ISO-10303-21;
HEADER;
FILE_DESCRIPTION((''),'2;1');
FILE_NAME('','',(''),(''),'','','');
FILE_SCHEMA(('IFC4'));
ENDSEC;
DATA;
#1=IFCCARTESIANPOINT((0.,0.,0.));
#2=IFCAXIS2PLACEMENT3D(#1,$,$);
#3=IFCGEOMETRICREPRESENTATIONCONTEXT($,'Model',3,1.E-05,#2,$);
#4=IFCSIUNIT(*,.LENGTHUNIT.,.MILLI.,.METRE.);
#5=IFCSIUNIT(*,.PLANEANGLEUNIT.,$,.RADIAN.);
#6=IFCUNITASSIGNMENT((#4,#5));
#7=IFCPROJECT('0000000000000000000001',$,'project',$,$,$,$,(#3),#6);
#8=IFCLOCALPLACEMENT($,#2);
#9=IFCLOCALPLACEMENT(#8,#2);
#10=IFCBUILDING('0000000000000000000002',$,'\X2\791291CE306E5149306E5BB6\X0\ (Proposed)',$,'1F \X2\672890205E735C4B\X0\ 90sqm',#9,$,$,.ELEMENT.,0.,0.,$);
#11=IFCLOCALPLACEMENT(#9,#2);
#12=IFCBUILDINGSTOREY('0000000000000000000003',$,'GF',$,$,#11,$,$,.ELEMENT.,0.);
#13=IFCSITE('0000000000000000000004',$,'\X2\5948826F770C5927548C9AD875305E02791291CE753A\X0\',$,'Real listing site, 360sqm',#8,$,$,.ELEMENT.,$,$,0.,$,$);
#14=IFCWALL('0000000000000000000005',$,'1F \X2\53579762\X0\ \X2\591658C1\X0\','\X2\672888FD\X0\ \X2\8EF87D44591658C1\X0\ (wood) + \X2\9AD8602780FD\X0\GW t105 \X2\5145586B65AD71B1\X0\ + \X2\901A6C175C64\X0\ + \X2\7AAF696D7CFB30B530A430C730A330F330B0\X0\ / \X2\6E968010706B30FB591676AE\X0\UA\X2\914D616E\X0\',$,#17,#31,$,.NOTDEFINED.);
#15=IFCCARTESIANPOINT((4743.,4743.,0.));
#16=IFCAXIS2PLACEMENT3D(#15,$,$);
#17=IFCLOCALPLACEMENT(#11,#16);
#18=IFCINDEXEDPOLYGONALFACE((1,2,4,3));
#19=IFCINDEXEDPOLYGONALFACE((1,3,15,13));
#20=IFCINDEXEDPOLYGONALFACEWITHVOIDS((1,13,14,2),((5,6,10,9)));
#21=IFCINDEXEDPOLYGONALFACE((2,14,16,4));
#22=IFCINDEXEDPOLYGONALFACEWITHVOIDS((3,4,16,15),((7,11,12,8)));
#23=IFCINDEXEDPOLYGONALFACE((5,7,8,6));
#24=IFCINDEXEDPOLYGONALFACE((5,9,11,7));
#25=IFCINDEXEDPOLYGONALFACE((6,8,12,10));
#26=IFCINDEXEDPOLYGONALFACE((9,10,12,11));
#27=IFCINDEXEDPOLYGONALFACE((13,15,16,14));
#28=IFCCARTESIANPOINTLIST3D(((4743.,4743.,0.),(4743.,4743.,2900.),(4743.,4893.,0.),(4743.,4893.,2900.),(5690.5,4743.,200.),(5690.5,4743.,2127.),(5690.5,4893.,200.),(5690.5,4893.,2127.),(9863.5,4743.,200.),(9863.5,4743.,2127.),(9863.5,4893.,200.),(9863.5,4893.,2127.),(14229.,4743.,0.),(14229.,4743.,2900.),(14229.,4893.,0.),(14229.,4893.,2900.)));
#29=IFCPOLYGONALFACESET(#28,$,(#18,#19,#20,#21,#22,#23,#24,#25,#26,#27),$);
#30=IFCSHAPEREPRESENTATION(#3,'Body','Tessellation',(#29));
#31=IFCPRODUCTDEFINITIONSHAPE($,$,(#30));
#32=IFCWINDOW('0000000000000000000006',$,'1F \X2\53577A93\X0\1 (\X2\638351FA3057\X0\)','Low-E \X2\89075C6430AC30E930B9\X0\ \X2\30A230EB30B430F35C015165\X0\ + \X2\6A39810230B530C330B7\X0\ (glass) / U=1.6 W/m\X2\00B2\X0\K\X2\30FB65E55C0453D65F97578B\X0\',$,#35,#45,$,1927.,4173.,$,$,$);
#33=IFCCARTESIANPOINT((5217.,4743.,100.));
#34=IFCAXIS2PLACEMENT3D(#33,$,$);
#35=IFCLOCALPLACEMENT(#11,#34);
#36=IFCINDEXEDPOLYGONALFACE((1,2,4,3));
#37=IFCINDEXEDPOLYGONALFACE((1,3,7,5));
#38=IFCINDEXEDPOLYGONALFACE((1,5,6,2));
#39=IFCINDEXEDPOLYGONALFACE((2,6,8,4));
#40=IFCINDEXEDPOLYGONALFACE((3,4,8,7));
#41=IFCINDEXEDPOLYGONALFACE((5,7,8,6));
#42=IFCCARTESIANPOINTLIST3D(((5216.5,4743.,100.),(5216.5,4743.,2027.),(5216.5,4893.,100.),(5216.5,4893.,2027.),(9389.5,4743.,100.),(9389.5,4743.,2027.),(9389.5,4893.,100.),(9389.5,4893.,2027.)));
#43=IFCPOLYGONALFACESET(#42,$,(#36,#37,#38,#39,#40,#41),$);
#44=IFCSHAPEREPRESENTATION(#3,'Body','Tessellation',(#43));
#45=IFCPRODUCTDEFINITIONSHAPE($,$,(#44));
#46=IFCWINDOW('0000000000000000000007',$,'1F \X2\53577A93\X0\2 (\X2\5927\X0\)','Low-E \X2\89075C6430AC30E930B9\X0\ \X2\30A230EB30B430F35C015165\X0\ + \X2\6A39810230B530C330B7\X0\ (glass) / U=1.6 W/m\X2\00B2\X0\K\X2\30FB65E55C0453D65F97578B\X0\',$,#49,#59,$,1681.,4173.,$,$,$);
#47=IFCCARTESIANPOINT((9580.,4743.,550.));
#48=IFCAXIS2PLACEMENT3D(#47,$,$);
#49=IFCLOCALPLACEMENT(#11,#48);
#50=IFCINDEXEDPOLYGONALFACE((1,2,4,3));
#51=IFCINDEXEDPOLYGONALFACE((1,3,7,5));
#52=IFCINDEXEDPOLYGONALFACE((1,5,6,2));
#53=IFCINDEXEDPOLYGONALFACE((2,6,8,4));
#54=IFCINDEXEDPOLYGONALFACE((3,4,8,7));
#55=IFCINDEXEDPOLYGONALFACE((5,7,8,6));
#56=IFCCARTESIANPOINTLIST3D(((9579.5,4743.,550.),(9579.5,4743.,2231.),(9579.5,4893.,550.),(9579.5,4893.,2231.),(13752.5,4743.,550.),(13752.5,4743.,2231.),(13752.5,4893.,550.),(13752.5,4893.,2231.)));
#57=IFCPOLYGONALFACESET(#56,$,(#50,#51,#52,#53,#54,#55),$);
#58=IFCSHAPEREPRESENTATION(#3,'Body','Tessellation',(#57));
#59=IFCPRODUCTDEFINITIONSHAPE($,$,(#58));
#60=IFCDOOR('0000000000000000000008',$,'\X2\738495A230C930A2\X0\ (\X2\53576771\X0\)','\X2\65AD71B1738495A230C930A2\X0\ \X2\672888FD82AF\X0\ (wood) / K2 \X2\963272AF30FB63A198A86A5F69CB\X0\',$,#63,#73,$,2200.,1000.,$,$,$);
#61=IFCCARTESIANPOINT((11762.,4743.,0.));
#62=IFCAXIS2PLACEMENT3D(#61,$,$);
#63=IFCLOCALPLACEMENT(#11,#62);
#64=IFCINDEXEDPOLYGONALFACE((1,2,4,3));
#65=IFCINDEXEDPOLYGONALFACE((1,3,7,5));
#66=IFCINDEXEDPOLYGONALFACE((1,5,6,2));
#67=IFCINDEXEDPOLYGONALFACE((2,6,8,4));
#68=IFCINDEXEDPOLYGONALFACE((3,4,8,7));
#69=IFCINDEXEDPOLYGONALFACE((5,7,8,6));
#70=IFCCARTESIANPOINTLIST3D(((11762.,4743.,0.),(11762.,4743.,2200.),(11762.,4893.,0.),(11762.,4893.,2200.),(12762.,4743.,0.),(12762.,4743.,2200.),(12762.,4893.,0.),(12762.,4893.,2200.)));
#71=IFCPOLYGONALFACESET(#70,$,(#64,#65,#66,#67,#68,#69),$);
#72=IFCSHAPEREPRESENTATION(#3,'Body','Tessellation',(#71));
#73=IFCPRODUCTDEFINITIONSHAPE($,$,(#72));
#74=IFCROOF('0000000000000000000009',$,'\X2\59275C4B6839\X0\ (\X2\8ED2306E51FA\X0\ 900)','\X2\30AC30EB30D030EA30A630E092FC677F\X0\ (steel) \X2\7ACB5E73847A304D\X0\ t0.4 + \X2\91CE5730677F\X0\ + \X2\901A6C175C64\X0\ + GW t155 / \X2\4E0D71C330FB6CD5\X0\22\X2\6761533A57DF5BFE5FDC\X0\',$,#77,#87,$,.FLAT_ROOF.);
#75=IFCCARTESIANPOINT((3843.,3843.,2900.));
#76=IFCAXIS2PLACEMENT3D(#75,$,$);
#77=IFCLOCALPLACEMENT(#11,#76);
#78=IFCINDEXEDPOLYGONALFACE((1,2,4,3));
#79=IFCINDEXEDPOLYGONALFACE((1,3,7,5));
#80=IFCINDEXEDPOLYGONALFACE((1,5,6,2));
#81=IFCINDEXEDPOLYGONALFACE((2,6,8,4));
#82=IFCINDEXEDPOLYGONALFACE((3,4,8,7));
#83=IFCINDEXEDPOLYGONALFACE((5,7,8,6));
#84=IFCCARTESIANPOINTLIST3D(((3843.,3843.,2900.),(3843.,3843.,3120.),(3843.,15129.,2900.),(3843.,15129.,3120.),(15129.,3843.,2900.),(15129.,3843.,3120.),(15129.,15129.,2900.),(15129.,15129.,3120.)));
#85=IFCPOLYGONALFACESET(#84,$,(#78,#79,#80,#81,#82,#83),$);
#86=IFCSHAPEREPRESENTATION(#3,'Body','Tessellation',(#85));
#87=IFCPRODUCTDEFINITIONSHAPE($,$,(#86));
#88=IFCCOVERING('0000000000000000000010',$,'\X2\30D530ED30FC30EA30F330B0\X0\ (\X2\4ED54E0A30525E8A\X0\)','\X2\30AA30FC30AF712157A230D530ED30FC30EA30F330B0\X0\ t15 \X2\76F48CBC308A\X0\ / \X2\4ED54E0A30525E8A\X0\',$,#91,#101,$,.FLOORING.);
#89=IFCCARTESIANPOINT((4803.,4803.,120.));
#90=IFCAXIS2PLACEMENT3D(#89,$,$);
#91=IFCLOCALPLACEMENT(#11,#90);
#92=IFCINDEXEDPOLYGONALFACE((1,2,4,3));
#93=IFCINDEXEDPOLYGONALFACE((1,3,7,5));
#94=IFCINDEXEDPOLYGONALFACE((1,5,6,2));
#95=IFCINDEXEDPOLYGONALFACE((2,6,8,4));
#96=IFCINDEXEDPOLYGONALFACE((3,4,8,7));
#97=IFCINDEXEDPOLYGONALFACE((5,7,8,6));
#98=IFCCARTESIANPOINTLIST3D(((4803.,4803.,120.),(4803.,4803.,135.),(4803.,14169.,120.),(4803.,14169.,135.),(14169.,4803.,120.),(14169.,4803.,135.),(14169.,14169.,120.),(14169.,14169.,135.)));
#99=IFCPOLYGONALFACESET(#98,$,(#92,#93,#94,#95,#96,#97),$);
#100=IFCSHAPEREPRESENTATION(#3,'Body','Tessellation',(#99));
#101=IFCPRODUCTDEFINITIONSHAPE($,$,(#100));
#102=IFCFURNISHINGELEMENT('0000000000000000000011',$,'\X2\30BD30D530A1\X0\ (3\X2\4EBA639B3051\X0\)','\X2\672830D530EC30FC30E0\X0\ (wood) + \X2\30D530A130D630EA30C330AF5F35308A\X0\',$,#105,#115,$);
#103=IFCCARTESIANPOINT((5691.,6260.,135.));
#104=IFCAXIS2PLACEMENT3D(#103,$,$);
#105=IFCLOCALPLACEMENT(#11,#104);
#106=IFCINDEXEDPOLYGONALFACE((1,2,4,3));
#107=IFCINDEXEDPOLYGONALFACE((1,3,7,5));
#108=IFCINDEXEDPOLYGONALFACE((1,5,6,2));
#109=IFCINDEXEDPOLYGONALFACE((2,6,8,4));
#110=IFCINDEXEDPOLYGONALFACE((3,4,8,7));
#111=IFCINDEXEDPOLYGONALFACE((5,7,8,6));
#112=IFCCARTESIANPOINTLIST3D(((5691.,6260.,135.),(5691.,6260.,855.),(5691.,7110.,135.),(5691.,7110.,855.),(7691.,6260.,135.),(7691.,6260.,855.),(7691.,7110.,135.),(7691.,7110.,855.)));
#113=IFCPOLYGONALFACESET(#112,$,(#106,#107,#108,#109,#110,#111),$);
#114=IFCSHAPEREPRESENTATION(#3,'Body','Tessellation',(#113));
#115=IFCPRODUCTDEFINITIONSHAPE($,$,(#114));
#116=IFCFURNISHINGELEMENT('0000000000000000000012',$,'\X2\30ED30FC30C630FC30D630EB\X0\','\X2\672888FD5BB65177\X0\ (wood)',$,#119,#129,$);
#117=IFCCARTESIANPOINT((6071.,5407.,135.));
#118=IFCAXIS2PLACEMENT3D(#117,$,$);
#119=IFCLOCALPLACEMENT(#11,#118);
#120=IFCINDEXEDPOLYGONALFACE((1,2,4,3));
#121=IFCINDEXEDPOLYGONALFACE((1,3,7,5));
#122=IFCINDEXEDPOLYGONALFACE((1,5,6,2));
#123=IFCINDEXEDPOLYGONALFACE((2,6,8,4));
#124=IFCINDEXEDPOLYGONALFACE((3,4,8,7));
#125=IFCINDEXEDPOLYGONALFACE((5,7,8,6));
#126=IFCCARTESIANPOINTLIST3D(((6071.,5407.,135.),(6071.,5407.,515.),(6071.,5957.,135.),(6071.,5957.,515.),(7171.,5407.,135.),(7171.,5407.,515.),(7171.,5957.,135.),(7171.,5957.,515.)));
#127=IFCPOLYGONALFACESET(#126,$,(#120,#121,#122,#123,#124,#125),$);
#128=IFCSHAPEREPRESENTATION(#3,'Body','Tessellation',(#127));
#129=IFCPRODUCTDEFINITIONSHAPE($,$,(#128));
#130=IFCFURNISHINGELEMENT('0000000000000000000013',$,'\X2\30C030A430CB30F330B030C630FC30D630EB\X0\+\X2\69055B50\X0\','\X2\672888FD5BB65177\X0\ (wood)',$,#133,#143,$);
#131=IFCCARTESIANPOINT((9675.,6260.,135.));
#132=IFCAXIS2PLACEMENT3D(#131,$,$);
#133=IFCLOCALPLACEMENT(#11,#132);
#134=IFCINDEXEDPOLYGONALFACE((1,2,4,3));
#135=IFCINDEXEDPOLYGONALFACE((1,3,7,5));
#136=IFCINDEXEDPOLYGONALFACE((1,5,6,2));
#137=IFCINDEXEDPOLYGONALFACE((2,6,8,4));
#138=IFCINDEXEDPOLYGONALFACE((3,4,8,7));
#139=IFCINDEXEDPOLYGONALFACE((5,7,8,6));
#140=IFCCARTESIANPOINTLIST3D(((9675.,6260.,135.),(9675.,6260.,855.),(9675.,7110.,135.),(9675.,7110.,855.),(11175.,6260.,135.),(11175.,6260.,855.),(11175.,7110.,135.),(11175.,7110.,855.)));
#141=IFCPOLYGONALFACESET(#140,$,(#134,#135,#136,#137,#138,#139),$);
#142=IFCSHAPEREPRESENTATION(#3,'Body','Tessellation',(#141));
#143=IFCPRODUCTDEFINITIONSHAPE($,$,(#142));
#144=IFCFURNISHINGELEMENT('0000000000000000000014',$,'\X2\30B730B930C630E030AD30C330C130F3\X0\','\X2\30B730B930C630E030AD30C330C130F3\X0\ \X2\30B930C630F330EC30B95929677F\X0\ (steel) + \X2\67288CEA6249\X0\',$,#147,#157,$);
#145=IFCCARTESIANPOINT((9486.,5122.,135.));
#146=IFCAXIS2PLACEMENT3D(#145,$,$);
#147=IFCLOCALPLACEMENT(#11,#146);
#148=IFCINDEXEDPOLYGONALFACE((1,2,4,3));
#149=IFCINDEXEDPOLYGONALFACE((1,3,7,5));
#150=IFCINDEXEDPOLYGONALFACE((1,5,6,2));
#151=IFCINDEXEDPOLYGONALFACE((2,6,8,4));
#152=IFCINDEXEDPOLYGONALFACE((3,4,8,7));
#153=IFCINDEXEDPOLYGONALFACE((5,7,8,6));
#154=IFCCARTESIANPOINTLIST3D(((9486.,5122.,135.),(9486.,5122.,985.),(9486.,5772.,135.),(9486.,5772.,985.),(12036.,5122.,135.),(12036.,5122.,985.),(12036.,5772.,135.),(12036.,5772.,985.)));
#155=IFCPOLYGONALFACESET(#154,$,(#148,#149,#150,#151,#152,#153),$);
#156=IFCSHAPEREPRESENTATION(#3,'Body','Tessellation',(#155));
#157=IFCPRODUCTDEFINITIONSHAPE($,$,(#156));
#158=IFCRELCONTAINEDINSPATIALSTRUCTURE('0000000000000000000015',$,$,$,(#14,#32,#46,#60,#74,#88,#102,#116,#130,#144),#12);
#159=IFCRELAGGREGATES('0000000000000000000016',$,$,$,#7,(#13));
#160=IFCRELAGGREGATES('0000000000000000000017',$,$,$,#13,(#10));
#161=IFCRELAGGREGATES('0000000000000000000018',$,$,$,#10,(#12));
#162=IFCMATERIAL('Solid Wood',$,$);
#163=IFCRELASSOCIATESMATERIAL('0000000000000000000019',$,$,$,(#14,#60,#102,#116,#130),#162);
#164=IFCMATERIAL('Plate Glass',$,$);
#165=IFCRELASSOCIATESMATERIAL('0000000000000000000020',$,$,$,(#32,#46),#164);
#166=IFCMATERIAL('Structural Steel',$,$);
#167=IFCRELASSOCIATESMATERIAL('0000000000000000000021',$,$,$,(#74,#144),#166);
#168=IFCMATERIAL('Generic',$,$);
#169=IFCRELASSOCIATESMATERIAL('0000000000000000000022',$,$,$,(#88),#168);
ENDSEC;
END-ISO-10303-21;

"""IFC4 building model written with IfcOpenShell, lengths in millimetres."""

from ifc_helpers import new_model, si_unit, frame, frame_2d, origin, place, context, project, spatial, rectangle, extrude, material, element, fill, save


model = new_model("IFC4")

# Units and contexts
model_context = context("Model", 3, precision=1e-05, world=origin())
ifc_project = project(units=[si_unit("LENGTHUNIT", "METRE", prefix="MILLI"), si_unit("PLANEANGLEUNIT", "RADIAN")], contexts=[model_context])

# Site, building, storey
site_placement = place(None, origin())
site = spatial("IfcSite", under=ifc_project, at=site_placement, Name="奈良県大和高田市礒野町", ObjectType="Real listing site, 360sqm", CompositionType="ELEMENT", RefElevation=0.0)
building_placement = place(site_placement, origin())
building = spatial("IfcBuilding", under=site, at=building_placement, Name="礒野の光の家 (Proposed)", ObjectType="1F 木造平屋 90sqm", CompositionType="ELEMENT", ElevationOfRefHeight=0.0, ElevationOfTerrain=0.0)
storey_placement = place(building_placement, origin())
storey = spatial("IfcBuildingStorey", under=building, at=storey_placement, Name="GF", CompositionType="ELEMENT", Elevation=0.0)

# Shared definitions
ifc_material_1 = material(Name="Solid Wood")

# Wall, openings, windows, door
wall_1_placement = place(storey_placement, frame((4743.0, 4743.0, 0.0)))
wall_1 = element("IfcWall", 1, at=wall_1_placement, inside=storey, material=ifc_material_1, Name="1F 南面 外壁", Description="木製 軸組外壁 (wood) + 高性能GW t105 充填断熱 + 通気層 + 窯業系サイディング / 準耐火・外皮UA配慮", PredefinedType="NOTDEFINED", context=model_context, shape_type="SweptSolid", body=[
    extrude(rectangle(XDim=9486.0, YDim=150.0, at=frame_2d((4743.0, 75.0))), frame((4743.0, 4743.0, 0.0)), (0.0, 0.0, 1.0), 2900.0),
])
opening_1_placement = place(storey_placement, frame((5217.0, 4743.0, 100.0)))
opening_1 = element("IfcOpeningElement", 2, at=opening_1_placement, cuts=wall_1, PredefinedType="NOTDEFINED", context=model_context, shape_type="SweptSolid", body=[
    extrude(rectangle(XDim=4173.0, YDim=150.0, at=frame_2d((2086.0, 75.0))), frame((5217.0, 4743.0, 100.0)), (0.0, 0.0, 1.0), 1927.0),
])
opening_2_placement = place(storey_placement, frame((9580.0, 4743.0, 550.0)))
opening_2 = element("IfcOpeningElement", 3, at=opening_2_placement, cuts=wall_1, PredefinedType="NOTDEFINED", context=model_context, shape_type="SweptSolid", body=[
    extrude(rectangle(XDim=4173.0, YDim=150.0, at=frame_2d((2086.0, 75.0))), frame((9580.0, 4743.0, 550.0)), (0.0, 0.0, 1.0), 1681.0),
])
opening_3_placement = place(storey_placement, frame((11762.0, 4743.0, 0.0)))
opening_3 = element("IfcOpeningElement", 4, at=opening_3_placement, cuts=wall_1, PredefinedType="NOTDEFINED", context=model_context, shape_type="SweptSolid", body=[
    extrude(rectangle(XDim=1000.0, YDim=150.0, at=frame_2d((500.0, 75.0))), frame((11762.0, 4743.0, 0.0)), (0.0, 0.0, 1.0), 2200.0),
])
ifc_material_2 = material(Name="Plate Glass")
window_1_placement = place(storey_placement, frame((5217.0, 4743.0, 100.0)))
window_1 = element("IfcWindow", 5, at=window_1_placement, inside=storey, material=ifc_material_2, Name="1F 南窓1 (掃出し)", Description="Low-E 複層ガラス アルゴン封入 + 樹脂サッシ (glass) / U=1.6 W/m²K・日射取得型", OverallHeight=1927.0, OverallWidth=4173.0, context=model_context, shape_type="SweptSolid", body=[
    extrude(rectangle(XDim=4173.0, YDim=150.0, at=frame_2d((2086.0, 75.0))), frame((5217.0, 4743.0, 100.0)), (0.0, 0.0, 1.0), 1927.0),
])
fill(opening_1, window_1)
window_2_placement = place(storey_placement, frame((9580.0, 4743.0, 550.0)))
window_2 = element("IfcWindow", 6, at=window_2_placement, inside=storey, material=ifc_material_2, Name="1F 南窓2 (大)", Description="Low-E 複層ガラス アルゴン封入 + 樹脂サッシ (glass) / U=1.6 W/m²K・日射取得型", OverallHeight=1681.0, OverallWidth=4173.0, context=model_context, shape_type="SweptSolid", body=[
    extrude(rectangle(XDim=4173.0, YDim=150.0, at=frame_2d((2086.0, 75.0))), frame((9580.0, 4743.0, 550.0)), (0.0, 0.0, 1.0), 1681.0),
])
fill(opening_2, window_2)
door_placement = place(storey_placement, frame((11762.0, 4743.0, 0.0)))
door = element("IfcDoor", 7, at=door_placement, inside=storey, material=ifc_material_1, Name="玄関ドア (南東)", Description="断熱玄関ドア 木製芯 (wood) / K2 防犯・採風機構", OverallHeight=2200.0, OverallWidth=1000.0, context=model_context, shape_type="SweptSolid", body=[
    extrude(rectangle(XDim=1000.0, YDim=150.0, at=frame_2d((500.0, 75.0))), frame((11762.0, 4743.0, 0.0)), (0.0, 0.0, 1.0), 2200.0),
])
fill(opening_3, door)

# Roof
ifc_material_3 = material(Name="Structural Steel")
roof_placement = place(storey_placement, frame((3843.0, 3843.0, 2900.0)))
element("IfcRoof", 8, at=roof_placement, inside=storey, material=ifc_material_3, Name="大屋根 (軒の出 900)", Description="ガルバリウム鋼板 (steel) 立平葺き t0.4 + 野地板 + 通気層 + GW t155 / 不燃・法22条区域対応", PredefinedType="FLAT_ROOF", context=model_context, shape_type="SweptSolid", body=[
    extrude(rectangle(XDim=11286.0, YDim=11286.0, at=frame_2d((5643.0, 5643.0))), frame((3843.0, 3843.0, 2900.0)), (0.0, 0.0, 1.0), 220.0),
])

# Covering
ifc_material_4 = material(Name="Generic")
covering_placement = place(storey_placement, frame((4803.0, 4803.0, 120.0)))
element("IfcCovering", 9, at=covering_placement, inside=storey, material=ifc_material_4, Name="フローリング (仕上げ床)", Description="オーク無垢フローリング t15 直貼り / 仕上げ床", PredefinedType="FLOORING", context=model_context, shape_type="SweptSolid", body=[
    extrude(rectangle(XDim=9366.0, YDim=9366.0, at=frame_2d((4683.0, 4683.0))), frame((4803.0, 4803.0, 120.0)), (0.0, 0.0, 1.0), 15.0),
])

# Furnishing elements
furnishing_1_placement = place(storey_placement, frame((5691.0, 6260.0, 135.0)))
element("IfcFurnishingElement", 10, at=furnishing_1_placement, inside=storey, material=ifc_material_1, Name="ソファ (3人掛け)", Description="木フレーム (wood) + ファブリック張り", context=model_context, shape_type="SweptSolid", body=[
    extrude(rectangle(XDim=2000.0, YDim=850.0, at=frame_2d((1000.0, 425.0))), frame((5691.0, 6260.0, 135.0)), (0.0, 0.0, 1.0), 720.0),
])
furnishing_2_placement = place(storey_placement, frame((6071.0, 5407.0, 135.0)))
element("IfcFurnishingElement", 11, at=furnishing_2_placement, inside=storey, material=ifc_material_1, Name="ローテーブル", Description="木製家具 (wood)", context=model_context, shape_type="SweptSolid", body=[
    extrude(rectangle(XDim=1100.0, YDim=550.0, at=frame_2d((550.0, 275.0))), frame((6071.0, 5407.0, 135.0)), (0.0, 0.0, 1.0), 380.0),
])
furnishing_3_placement = place(storey_placement, frame((9675.0, 6260.0, 135.0)))
element("IfcFurnishingElement", 12, at=furnishing_3_placement, inside=storey, material=ifc_material_1, Name="ダイニングテーブル+椅子", Description="木製家具 (wood)", context=model_context, shape_type="SweptSolid", body=[
    extrude(rectangle(XDim=1500.0, YDim=850.0, at=frame_2d((750.0, 425.0))), frame((9675.0, 6260.0, 135.0)), (0.0, 0.0, 1.0), 720.0),
])
furnishing_4_placement = place(storey_placement, frame((9486.0, 5122.0, 135.0)))
element("IfcFurnishingElement", 13, at=furnishing_4_placement, inside=storey, material=ifc_material_3, Name="システムキッチン", Description="システムキッチン ステンレス天板 (steel) + 木質扉", context=model_context, shape_type="SweptSolid", body=[
    extrude(rectangle(XDim=2550.0, YDim=650.0, at=frame_2d((1275.0, 325.0))), frame((9486.0, 5122.0, 135.0)), (0.0, 0.0, 1.0), 850.0),
])

save(model, "model.ifc")
